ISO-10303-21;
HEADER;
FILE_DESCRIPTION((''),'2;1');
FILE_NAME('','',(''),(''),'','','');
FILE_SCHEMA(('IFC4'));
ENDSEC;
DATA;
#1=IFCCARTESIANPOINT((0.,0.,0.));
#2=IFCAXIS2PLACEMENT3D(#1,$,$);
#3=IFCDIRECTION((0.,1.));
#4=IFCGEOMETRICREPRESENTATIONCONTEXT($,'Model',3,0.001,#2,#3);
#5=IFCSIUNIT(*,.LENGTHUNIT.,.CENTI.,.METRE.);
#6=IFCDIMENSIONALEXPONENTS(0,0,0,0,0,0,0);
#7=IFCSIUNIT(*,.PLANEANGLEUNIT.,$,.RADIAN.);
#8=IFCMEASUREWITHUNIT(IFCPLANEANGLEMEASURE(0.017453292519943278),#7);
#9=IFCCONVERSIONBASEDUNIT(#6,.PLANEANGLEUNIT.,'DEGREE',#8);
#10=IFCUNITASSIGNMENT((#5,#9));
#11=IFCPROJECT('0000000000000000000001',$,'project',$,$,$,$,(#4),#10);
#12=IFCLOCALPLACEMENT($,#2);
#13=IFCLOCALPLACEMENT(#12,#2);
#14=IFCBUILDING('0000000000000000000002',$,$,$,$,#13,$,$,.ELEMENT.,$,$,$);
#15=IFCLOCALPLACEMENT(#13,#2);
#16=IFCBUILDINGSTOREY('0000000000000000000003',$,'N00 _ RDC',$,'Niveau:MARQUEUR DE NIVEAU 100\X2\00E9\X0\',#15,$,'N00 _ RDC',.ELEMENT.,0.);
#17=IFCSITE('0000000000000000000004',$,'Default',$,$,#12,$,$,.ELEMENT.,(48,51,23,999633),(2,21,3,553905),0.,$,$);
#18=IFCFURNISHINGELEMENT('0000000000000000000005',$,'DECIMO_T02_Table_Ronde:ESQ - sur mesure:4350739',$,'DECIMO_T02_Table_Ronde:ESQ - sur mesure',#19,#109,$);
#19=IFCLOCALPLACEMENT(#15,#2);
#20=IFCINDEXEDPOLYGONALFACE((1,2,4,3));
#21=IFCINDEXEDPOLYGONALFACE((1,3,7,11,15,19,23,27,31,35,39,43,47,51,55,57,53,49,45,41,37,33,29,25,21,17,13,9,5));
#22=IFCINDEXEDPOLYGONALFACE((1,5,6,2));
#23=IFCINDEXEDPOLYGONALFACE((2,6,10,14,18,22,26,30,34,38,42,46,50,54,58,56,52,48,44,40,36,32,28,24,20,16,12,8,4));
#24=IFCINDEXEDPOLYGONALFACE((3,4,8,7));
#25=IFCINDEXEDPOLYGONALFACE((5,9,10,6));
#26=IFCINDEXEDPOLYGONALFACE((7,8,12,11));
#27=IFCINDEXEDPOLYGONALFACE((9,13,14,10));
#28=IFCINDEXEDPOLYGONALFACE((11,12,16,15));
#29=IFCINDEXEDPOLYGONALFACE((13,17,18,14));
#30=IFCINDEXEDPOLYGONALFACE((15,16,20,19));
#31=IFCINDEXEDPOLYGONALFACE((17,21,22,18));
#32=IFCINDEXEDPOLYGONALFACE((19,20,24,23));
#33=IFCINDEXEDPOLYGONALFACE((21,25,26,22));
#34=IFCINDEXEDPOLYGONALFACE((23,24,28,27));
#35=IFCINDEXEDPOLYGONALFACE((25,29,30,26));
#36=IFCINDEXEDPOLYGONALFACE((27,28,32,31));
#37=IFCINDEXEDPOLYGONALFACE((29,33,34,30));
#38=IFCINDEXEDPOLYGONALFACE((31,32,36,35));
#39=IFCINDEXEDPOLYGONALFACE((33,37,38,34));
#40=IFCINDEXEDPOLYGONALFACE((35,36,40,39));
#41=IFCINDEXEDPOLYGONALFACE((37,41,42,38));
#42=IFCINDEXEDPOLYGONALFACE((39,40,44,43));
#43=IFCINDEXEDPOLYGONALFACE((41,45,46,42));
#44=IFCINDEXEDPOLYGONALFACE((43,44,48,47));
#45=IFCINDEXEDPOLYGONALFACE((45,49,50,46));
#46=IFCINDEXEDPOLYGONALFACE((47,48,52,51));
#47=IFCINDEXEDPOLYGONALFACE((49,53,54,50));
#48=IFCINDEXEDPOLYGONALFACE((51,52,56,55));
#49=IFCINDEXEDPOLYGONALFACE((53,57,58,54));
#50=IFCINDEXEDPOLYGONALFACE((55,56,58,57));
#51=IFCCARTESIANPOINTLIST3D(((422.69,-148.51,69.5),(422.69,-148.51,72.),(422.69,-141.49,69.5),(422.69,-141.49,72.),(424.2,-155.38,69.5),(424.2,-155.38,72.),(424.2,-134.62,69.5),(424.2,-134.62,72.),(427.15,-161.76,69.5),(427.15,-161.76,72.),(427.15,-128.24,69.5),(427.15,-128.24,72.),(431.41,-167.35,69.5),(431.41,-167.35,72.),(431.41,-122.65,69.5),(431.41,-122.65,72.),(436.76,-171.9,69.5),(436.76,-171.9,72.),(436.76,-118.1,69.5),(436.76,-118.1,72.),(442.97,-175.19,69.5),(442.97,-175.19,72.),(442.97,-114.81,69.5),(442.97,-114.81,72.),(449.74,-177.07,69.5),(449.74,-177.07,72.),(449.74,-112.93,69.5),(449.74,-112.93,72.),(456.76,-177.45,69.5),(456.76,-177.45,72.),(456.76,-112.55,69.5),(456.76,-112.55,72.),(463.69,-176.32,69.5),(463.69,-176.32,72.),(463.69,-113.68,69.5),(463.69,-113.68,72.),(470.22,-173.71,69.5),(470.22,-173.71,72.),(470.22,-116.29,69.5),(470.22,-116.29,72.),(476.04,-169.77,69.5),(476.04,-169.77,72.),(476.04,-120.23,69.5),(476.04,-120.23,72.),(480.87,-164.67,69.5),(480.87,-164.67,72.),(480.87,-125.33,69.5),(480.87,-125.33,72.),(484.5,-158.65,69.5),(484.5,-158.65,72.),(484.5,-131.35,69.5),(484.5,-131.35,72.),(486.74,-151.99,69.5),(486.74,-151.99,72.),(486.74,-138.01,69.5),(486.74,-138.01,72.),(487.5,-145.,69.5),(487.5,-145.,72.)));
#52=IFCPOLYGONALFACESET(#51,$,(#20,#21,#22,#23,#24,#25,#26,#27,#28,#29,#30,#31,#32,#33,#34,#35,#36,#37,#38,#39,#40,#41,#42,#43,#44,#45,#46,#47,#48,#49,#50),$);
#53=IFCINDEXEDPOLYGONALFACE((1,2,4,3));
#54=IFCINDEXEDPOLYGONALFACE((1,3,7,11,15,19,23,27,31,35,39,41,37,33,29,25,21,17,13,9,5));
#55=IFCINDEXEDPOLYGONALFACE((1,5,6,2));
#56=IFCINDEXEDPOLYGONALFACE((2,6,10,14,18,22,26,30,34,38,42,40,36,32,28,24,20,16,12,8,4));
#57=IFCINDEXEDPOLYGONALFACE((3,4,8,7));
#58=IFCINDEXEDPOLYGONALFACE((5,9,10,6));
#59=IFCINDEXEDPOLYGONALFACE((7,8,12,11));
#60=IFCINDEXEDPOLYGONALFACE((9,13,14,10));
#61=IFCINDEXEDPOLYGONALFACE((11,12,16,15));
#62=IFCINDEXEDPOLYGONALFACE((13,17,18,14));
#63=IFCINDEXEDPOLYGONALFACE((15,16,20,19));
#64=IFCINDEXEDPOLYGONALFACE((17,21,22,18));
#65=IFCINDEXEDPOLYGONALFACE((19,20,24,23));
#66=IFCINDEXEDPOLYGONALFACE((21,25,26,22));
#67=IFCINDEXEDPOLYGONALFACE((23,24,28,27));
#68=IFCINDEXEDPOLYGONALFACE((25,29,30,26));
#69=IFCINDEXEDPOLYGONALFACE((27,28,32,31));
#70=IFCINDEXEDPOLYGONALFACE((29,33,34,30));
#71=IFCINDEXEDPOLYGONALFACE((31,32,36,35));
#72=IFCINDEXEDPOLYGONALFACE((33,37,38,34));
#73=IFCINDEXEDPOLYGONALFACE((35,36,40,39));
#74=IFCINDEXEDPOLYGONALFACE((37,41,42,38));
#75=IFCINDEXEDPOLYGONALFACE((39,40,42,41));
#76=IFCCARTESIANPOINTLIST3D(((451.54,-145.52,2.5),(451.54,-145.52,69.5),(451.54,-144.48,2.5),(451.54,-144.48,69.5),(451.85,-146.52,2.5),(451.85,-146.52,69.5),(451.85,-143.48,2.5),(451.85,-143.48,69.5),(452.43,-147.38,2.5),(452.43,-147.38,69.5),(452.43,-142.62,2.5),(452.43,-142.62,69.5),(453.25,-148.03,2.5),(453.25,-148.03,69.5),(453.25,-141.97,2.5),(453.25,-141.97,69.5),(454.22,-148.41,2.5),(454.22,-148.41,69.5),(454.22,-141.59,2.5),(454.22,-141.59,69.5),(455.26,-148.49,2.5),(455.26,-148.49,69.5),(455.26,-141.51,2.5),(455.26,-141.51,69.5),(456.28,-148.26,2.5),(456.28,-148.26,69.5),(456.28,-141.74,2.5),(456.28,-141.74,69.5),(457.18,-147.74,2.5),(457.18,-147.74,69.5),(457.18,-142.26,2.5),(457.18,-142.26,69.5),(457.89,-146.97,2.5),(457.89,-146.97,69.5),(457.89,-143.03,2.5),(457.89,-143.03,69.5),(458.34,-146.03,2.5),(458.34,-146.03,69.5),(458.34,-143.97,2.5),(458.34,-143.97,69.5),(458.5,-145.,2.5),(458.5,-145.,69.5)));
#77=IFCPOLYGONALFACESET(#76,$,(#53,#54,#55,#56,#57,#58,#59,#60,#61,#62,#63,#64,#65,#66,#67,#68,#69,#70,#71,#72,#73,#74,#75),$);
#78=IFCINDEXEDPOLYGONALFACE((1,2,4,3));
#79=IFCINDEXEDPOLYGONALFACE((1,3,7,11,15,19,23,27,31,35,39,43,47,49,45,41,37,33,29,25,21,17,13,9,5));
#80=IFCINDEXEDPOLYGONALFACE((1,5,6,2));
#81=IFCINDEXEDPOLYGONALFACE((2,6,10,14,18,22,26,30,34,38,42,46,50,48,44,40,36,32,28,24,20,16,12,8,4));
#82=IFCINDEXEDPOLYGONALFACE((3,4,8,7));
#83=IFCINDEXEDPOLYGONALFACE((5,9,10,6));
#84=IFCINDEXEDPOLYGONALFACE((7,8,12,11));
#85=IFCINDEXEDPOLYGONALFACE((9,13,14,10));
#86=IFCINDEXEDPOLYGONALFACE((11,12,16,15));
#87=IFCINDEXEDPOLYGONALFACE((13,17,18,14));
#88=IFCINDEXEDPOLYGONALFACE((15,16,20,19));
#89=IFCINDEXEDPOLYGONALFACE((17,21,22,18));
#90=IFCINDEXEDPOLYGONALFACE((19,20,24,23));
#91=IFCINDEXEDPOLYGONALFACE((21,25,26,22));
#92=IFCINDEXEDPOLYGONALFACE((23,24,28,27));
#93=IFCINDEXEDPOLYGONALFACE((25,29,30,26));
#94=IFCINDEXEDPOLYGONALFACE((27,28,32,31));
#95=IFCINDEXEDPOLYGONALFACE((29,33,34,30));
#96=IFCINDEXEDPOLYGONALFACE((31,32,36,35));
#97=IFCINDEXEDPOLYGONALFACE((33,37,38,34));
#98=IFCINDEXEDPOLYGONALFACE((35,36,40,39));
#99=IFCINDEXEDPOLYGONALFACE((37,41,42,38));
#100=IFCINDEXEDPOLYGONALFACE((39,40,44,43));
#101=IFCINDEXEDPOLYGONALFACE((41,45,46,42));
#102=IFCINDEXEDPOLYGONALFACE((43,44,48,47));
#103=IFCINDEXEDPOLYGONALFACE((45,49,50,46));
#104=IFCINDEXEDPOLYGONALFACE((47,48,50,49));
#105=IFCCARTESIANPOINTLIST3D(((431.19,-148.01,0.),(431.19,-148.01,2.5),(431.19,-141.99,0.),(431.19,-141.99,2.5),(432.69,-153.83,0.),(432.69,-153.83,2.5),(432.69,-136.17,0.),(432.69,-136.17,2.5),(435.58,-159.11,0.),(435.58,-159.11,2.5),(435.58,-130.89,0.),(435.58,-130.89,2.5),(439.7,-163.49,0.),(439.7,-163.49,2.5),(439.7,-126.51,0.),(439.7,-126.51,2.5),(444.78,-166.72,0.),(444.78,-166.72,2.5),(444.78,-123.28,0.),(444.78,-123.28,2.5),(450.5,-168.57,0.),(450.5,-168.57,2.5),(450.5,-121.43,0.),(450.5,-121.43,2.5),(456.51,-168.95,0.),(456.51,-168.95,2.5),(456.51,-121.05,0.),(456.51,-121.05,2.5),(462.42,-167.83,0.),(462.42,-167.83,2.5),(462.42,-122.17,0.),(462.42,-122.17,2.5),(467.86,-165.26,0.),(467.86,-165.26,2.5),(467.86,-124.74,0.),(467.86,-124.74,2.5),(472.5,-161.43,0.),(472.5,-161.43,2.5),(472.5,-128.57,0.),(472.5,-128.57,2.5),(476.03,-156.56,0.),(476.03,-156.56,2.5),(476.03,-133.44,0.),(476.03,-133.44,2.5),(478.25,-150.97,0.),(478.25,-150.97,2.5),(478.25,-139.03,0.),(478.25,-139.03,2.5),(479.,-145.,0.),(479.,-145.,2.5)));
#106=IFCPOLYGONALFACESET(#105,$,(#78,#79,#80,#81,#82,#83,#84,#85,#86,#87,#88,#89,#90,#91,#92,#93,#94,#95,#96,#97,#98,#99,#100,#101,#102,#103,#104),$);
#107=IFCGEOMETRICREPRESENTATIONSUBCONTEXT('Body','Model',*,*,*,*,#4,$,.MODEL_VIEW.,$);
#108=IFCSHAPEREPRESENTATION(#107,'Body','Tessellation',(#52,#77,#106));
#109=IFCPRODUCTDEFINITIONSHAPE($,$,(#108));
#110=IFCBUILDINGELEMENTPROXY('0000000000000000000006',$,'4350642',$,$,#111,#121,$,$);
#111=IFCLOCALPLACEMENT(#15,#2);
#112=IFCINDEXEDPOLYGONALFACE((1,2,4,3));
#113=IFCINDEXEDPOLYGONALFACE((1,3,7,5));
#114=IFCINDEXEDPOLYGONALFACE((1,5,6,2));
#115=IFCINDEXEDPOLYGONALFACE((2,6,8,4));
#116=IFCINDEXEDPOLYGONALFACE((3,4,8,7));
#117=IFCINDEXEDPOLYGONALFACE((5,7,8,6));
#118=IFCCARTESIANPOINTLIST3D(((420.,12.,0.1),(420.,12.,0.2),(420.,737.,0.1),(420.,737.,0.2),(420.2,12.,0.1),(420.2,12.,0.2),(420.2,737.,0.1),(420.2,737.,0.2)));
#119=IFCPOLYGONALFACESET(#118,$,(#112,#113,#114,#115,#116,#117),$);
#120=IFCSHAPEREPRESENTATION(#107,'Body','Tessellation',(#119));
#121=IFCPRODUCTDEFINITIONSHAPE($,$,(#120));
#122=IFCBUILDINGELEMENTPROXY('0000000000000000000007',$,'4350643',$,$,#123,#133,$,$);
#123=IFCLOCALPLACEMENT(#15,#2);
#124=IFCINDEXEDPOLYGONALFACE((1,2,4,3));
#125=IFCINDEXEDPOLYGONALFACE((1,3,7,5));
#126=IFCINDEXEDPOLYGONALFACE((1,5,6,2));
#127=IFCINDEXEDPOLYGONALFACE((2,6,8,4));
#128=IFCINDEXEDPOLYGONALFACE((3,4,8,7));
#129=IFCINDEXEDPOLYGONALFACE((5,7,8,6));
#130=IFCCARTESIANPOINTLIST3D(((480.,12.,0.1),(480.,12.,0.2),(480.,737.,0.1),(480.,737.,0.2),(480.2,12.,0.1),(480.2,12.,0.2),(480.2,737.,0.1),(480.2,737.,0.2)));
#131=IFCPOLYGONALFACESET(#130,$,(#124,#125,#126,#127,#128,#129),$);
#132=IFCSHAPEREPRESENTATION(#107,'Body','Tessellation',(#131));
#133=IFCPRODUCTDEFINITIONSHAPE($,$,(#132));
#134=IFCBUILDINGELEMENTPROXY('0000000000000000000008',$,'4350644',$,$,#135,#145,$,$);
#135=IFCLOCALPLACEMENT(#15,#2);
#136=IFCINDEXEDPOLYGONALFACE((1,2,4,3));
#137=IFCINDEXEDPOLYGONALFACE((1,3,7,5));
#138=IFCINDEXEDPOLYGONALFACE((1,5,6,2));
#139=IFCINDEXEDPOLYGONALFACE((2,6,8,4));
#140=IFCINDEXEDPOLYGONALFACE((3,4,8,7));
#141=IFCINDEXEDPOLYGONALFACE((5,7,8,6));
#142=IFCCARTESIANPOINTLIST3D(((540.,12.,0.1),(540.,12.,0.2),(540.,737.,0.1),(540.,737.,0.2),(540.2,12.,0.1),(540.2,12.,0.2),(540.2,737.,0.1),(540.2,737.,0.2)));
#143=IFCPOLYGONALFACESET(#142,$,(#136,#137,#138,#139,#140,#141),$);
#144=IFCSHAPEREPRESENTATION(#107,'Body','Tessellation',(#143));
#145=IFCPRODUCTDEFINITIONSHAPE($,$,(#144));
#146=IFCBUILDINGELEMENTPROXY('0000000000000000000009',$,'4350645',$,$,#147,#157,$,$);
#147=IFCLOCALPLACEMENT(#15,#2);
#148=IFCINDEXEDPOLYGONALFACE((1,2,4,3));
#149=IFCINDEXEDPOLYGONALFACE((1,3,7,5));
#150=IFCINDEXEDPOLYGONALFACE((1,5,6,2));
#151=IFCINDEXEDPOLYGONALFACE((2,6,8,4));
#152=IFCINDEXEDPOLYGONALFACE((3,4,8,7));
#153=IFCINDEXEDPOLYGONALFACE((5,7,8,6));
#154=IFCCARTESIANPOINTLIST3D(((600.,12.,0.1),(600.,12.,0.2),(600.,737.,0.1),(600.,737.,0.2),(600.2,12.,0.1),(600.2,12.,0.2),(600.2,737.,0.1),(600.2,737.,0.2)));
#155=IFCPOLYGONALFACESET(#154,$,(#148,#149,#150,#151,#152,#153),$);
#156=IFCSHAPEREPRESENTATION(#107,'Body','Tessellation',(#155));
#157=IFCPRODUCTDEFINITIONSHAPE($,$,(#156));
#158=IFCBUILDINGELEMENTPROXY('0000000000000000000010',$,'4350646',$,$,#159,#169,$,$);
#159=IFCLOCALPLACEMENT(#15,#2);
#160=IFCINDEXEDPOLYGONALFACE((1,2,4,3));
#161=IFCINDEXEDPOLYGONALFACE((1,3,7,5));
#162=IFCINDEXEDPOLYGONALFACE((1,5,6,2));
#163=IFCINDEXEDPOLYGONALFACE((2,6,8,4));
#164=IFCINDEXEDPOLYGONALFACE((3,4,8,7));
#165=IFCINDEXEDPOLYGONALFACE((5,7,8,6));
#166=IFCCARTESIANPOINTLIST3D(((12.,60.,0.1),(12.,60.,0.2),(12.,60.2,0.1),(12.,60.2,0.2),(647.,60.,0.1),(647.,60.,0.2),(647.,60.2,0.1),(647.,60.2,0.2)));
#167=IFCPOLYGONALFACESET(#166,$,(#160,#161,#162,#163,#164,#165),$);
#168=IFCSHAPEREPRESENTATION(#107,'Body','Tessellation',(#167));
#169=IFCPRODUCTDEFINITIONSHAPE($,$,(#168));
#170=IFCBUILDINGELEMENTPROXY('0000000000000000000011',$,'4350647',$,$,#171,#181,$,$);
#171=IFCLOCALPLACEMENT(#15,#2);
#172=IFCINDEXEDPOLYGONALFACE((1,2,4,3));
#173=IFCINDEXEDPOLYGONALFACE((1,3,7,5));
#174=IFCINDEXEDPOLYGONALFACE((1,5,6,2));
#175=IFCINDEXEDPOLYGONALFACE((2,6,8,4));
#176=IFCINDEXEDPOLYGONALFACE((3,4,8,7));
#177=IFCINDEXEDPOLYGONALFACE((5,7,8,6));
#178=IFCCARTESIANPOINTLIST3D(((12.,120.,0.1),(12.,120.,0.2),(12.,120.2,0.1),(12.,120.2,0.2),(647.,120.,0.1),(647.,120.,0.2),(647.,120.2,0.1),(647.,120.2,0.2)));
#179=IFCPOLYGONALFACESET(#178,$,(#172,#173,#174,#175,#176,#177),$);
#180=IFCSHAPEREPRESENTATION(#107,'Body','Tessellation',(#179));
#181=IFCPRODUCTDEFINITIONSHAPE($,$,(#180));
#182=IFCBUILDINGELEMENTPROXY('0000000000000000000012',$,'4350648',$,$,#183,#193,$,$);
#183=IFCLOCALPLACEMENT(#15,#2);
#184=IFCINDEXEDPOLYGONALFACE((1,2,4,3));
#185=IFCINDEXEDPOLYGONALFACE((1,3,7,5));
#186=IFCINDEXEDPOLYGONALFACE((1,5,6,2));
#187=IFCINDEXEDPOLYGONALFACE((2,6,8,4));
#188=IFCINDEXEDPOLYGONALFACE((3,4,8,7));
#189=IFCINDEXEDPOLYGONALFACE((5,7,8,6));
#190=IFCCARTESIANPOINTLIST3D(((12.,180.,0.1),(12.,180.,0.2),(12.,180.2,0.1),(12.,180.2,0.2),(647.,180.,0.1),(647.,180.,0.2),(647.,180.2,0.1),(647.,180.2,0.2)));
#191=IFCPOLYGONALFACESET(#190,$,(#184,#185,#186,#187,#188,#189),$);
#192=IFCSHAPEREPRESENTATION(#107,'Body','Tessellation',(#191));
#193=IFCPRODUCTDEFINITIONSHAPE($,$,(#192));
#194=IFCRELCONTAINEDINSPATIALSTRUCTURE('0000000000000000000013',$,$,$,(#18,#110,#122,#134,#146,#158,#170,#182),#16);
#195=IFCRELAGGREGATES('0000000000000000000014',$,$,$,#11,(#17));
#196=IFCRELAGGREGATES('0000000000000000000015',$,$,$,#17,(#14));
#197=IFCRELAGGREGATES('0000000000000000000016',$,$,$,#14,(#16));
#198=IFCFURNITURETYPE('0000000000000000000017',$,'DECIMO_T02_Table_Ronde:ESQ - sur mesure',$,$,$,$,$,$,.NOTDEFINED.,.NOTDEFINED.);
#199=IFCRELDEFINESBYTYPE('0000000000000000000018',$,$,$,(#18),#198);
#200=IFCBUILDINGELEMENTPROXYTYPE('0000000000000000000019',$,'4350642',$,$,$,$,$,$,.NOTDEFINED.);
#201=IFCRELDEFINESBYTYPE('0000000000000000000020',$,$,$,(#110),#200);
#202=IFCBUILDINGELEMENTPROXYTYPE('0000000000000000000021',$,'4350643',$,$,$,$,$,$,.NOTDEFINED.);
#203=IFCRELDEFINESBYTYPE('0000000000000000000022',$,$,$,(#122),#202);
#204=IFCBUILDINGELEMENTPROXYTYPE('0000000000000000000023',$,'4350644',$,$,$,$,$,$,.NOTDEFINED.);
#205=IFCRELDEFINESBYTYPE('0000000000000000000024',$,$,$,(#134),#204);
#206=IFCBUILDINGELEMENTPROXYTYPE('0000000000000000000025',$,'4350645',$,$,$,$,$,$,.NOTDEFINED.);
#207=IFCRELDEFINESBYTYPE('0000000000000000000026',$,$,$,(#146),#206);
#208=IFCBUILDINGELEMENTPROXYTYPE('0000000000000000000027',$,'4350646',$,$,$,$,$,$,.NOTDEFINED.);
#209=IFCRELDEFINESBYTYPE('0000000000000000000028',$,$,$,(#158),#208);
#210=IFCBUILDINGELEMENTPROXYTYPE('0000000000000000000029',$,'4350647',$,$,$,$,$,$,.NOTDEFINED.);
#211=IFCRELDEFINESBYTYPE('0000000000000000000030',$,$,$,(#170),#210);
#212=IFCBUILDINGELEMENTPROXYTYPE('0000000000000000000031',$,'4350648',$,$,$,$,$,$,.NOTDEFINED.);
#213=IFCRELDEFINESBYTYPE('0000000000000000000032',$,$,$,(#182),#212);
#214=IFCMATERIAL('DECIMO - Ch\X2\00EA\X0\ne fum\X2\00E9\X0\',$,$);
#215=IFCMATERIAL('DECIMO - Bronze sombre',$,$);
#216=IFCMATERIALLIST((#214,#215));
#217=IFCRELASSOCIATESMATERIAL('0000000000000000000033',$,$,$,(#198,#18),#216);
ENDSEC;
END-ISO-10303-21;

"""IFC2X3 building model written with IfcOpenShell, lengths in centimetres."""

from ifc_helpers import new_model, entity, si_unit, converted_unit, direction, frame, frame_2d, origin, origin_2d_with_axis, place, context, subcontext, project, spatial, rectangle, circle, extrude, source, transform, mapped, material, material_list, type_object, type_shapes, element, save


model = new_model("IFC2X3")

# Units and contexts
model_context = context("Model", 3, precision=0.001, world=origin(), true_north=direction((0.0, 1.0)))
body_context = subcontext(model_context, "Body", "Model", "MODEL_VIEW")
ifc_project = project(units=[si_unit("LENGTHUNIT", "METRE", prefix="CENTI"), converted_unit("PLANEANGLEUNIT", "DEGREE", entity("IfcPlaneAngleMeasure", 0.017453292519943278), si_unit("PLANEANGLEUNIT", "RADIAN"), dimensions=[0, 0, 0, 0, 0, 0, 0])], contexts=[model_context])

# Site, building, storey
site_placement = place(None, origin())
site = spatial("IfcSite", under=ifc_project, at=site_placement, Name="Default", CompositionType="ELEMENT", RefLatitude=(48, 51, 23, 999633), RefLongitude=(2, 21, 3, 553905), RefElevation=0.0)
building_placement = place(site_placement, origin())
building = spatial("IfcBuilding", under=site, at=building_placement, CompositionType="ELEMENT")
storey_placement = place(building_placement, origin())
storey = spatial("IfcBuildingStorey", under=building, at=storey_placement, Name="N00 _ RDC", ObjectType="Niveau:MARQUEUR DE NIVEAU 100é", LongName="N00 _ RDC", CompositionType="ELEMENT", Elevation=0.0)

# Furnishing element
ifc_material_1 = material(Name="DECIMO - Chêne fumé")
ifc_material_2 = material(Name="DECIMO - Bronze sombre")
ifc_material_list_1 = material_list([ifc_material_1, ifc_material_2])
furniture_type_1 = type_object("IfcFurnitureType", Name="DECIMO_T02_Table_Ronde:ESQ - sur mesure", AssemblyPlace="NOTDEFINED", material=ifc_material_list_1)
shared_shape_1 = source(origin(), body_context, "Body", "SweptSolid", [
    extrude(circle(Radius=32.5, at=frame_2d((0.0, 0.0), x_axis=(1.0, 0.0))), frame((0.0, 0.0, 69.5)), (0.0, 0.0, 1.0), 2.5),
    extrude(circle(Radius=3.5, at=frame_2d((0.0, 0.0), x_axis=(1.0, 0.0))), frame((0.0, 0.0, 2.5)), (0.0, 0.0, 1.0), 67.0),
    extrude(circle(Radius=24.0, at=frame_2d((0.0, 0.0), x_axis=(1.0, 0.0))), origin(), (0.0, 0.0, 1.0), 2.5),
])
type_shapes(furniture_type_1, [shared_shape_1])
for number, where, name in (
    (1, (455.0, -145.0, 0.0), "DECIMO_T02_Table_Ronde:ESQ - sur mesure:4350739"),
):
    element("IfcFurnishingElement", number, at=place(storey_placement, frame(where)), inside=storey, type_object=furniture_type_1, material=ifc_material_list_1, Name=name, ObjectType="DECIMO_T02_Table_Ronde:ESQ - sur mesure", context=body_context, shape_type="MappedRepresentation", body=[
        mapped(shared_shape_1, transform((0.0, 0.0, 0.0), scale=1.0)),
    ])

# Building element proxies
building_element_proxy_type_1 = type_object("IfcBuildingElementProxyType", Name="4350642", PredefinedType="NOTDEFINED")
proxy_1_placement = place(storey_placement, origin())
element("IfcBuildingElementProxy", 2, at=proxy_1_placement, inside=storey, type_object=building_element_proxy_type_1, Name="4350642", context=body_context, shape_type="SweptSolid", body=[
    extrude(rectangle(XDim=0.2, YDim=725.0, at=origin_2d_with_axis()), frame((420.1, 374.5, 0.1)), (0.0, 0.0, 1.0), 0.1),
])
building_element_proxy_type_2 = type_object("IfcBuildingElementProxyType", Name="4350643", PredefinedType="NOTDEFINED")
proxy_2_placement = place(storey_placement, origin())
element("IfcBuildingElementProxy", 3, at=proxy_2_placement, inside=storey, type_object=building_element_proxy_type_2, Name="4350643", context=body_context, shape_type="SweptSolid", body=[
    extrude(rectangle(XDim=0.2, YDim=725.0, at=origin_2d_with_axis()), frame((480.1, 374.5, 0.1)), (0.0, 0.0, 1.0), 0.1),
])
building_element_proxy_type_3 = type_object("IfcBuildingElementProxyType", Name="4350644", PredefinedType="NOTDEFINED")
proxy_3_placement = place(storey_placement, origin())
element("IfcBuildingElementProxy", 4, at=proxy_3_placement, inside=storey, type_object=building_element_proxy_type_3, Name="4350644", context=body_context, shape_type="SweptSolid", body=[
    extrude(rectangle(XDim=0.2, YDim=725.0, at=origin_2d_with_axis()), frame((540.1, 374.5, 0.1)), (0.0, 0.0, 1.0), 0.1),
])
building_element_proxy_type_4 = type_object("IfcBuildingElementProxyType", Name="4350645", PredefinedType="NOTDEFINED")
proxy_4_placement = place(storey_placement, origin())
element("IfcBuildingElementProxy", 5, at=proxy_4_placement, inside=storey, type_object=building_element_proxy_type_4, Name="4350645", context=body_context, shape_type="SweptSolid", body=[
    extrude(rectangle(XDim=0.2, YDim=725.0, at=origin_2d_with_axis()), frame((600.1, 374.5, 0.1)), (0.0, 0.0, 1.0), 0.1),
])
building_element_proxy_type_5 = type_object("IfcBuildingElementProxyType", Name="4350646", PredefinedType="NOTDEFINED")
proxy_5_placement = place(storey_placement, origin())
element("IfcBuildingElementProxy", 6, at=proxy_5_placement, inside=storey, type_object=building_element_proxy_type_5, Name="4350646", context=body_context, shape_type="SweptSolid", body=[
    extrude(rectangle(XDim=635.0, YDim=0.2, at=frame_2d((0.0, 0.0), x_axis=(1.0, 0.0))), frame((329.5, 60.1, 0.1)), (0.0, 0.0, 1.0), 0.1),
])
building_element_proxy_type_6 = type_object("IfcBuildingElementProxyType", Name="4350647", PredefinedType="NOTDEFINED")
proxy_6_placement = place(storey_placement, origin())
element("IfcBuildingElementProxy", 7, at=proxy_6_placement, inside=storey, type_object=building_element_proxy_type_6, Name="4350647", context=body_context, shape_type="SweptSolid", body=[
    extrude(rectangle(XDim=635.0, YDim=0.2, at=frame_2d((0.0, 0.0), x_axis=(1.0, 0.0))), frame((329.5, 120.1, 0.1)), (0.0, 0.0, 1.0), 0.1),
])
building_element_proxy_type_7 = type_object("IfcBuildingElementProxyType", Name="4350648", PredefinedType="NOTDEFINED")
proxy_7_placement = place(storey_placement, origin())
element("IfcBuildingElementProxy", 8, at=proxy_7_placement, inside=storey, type_object=building_element_proxy_type_7, Name="4350648", context=body_context, shape_type="SweptSolid", body=[
    extrude(rectangle(XDim=635.0, YDim=0.2, at=frame_2d((0.0, 0.0), x_axis=(1.0, 0.0))), frame((329.5, 180.1, 0.1)), (0.0, 0.0, 1.0), 0.1),
])

save(model, "model.ifc")
